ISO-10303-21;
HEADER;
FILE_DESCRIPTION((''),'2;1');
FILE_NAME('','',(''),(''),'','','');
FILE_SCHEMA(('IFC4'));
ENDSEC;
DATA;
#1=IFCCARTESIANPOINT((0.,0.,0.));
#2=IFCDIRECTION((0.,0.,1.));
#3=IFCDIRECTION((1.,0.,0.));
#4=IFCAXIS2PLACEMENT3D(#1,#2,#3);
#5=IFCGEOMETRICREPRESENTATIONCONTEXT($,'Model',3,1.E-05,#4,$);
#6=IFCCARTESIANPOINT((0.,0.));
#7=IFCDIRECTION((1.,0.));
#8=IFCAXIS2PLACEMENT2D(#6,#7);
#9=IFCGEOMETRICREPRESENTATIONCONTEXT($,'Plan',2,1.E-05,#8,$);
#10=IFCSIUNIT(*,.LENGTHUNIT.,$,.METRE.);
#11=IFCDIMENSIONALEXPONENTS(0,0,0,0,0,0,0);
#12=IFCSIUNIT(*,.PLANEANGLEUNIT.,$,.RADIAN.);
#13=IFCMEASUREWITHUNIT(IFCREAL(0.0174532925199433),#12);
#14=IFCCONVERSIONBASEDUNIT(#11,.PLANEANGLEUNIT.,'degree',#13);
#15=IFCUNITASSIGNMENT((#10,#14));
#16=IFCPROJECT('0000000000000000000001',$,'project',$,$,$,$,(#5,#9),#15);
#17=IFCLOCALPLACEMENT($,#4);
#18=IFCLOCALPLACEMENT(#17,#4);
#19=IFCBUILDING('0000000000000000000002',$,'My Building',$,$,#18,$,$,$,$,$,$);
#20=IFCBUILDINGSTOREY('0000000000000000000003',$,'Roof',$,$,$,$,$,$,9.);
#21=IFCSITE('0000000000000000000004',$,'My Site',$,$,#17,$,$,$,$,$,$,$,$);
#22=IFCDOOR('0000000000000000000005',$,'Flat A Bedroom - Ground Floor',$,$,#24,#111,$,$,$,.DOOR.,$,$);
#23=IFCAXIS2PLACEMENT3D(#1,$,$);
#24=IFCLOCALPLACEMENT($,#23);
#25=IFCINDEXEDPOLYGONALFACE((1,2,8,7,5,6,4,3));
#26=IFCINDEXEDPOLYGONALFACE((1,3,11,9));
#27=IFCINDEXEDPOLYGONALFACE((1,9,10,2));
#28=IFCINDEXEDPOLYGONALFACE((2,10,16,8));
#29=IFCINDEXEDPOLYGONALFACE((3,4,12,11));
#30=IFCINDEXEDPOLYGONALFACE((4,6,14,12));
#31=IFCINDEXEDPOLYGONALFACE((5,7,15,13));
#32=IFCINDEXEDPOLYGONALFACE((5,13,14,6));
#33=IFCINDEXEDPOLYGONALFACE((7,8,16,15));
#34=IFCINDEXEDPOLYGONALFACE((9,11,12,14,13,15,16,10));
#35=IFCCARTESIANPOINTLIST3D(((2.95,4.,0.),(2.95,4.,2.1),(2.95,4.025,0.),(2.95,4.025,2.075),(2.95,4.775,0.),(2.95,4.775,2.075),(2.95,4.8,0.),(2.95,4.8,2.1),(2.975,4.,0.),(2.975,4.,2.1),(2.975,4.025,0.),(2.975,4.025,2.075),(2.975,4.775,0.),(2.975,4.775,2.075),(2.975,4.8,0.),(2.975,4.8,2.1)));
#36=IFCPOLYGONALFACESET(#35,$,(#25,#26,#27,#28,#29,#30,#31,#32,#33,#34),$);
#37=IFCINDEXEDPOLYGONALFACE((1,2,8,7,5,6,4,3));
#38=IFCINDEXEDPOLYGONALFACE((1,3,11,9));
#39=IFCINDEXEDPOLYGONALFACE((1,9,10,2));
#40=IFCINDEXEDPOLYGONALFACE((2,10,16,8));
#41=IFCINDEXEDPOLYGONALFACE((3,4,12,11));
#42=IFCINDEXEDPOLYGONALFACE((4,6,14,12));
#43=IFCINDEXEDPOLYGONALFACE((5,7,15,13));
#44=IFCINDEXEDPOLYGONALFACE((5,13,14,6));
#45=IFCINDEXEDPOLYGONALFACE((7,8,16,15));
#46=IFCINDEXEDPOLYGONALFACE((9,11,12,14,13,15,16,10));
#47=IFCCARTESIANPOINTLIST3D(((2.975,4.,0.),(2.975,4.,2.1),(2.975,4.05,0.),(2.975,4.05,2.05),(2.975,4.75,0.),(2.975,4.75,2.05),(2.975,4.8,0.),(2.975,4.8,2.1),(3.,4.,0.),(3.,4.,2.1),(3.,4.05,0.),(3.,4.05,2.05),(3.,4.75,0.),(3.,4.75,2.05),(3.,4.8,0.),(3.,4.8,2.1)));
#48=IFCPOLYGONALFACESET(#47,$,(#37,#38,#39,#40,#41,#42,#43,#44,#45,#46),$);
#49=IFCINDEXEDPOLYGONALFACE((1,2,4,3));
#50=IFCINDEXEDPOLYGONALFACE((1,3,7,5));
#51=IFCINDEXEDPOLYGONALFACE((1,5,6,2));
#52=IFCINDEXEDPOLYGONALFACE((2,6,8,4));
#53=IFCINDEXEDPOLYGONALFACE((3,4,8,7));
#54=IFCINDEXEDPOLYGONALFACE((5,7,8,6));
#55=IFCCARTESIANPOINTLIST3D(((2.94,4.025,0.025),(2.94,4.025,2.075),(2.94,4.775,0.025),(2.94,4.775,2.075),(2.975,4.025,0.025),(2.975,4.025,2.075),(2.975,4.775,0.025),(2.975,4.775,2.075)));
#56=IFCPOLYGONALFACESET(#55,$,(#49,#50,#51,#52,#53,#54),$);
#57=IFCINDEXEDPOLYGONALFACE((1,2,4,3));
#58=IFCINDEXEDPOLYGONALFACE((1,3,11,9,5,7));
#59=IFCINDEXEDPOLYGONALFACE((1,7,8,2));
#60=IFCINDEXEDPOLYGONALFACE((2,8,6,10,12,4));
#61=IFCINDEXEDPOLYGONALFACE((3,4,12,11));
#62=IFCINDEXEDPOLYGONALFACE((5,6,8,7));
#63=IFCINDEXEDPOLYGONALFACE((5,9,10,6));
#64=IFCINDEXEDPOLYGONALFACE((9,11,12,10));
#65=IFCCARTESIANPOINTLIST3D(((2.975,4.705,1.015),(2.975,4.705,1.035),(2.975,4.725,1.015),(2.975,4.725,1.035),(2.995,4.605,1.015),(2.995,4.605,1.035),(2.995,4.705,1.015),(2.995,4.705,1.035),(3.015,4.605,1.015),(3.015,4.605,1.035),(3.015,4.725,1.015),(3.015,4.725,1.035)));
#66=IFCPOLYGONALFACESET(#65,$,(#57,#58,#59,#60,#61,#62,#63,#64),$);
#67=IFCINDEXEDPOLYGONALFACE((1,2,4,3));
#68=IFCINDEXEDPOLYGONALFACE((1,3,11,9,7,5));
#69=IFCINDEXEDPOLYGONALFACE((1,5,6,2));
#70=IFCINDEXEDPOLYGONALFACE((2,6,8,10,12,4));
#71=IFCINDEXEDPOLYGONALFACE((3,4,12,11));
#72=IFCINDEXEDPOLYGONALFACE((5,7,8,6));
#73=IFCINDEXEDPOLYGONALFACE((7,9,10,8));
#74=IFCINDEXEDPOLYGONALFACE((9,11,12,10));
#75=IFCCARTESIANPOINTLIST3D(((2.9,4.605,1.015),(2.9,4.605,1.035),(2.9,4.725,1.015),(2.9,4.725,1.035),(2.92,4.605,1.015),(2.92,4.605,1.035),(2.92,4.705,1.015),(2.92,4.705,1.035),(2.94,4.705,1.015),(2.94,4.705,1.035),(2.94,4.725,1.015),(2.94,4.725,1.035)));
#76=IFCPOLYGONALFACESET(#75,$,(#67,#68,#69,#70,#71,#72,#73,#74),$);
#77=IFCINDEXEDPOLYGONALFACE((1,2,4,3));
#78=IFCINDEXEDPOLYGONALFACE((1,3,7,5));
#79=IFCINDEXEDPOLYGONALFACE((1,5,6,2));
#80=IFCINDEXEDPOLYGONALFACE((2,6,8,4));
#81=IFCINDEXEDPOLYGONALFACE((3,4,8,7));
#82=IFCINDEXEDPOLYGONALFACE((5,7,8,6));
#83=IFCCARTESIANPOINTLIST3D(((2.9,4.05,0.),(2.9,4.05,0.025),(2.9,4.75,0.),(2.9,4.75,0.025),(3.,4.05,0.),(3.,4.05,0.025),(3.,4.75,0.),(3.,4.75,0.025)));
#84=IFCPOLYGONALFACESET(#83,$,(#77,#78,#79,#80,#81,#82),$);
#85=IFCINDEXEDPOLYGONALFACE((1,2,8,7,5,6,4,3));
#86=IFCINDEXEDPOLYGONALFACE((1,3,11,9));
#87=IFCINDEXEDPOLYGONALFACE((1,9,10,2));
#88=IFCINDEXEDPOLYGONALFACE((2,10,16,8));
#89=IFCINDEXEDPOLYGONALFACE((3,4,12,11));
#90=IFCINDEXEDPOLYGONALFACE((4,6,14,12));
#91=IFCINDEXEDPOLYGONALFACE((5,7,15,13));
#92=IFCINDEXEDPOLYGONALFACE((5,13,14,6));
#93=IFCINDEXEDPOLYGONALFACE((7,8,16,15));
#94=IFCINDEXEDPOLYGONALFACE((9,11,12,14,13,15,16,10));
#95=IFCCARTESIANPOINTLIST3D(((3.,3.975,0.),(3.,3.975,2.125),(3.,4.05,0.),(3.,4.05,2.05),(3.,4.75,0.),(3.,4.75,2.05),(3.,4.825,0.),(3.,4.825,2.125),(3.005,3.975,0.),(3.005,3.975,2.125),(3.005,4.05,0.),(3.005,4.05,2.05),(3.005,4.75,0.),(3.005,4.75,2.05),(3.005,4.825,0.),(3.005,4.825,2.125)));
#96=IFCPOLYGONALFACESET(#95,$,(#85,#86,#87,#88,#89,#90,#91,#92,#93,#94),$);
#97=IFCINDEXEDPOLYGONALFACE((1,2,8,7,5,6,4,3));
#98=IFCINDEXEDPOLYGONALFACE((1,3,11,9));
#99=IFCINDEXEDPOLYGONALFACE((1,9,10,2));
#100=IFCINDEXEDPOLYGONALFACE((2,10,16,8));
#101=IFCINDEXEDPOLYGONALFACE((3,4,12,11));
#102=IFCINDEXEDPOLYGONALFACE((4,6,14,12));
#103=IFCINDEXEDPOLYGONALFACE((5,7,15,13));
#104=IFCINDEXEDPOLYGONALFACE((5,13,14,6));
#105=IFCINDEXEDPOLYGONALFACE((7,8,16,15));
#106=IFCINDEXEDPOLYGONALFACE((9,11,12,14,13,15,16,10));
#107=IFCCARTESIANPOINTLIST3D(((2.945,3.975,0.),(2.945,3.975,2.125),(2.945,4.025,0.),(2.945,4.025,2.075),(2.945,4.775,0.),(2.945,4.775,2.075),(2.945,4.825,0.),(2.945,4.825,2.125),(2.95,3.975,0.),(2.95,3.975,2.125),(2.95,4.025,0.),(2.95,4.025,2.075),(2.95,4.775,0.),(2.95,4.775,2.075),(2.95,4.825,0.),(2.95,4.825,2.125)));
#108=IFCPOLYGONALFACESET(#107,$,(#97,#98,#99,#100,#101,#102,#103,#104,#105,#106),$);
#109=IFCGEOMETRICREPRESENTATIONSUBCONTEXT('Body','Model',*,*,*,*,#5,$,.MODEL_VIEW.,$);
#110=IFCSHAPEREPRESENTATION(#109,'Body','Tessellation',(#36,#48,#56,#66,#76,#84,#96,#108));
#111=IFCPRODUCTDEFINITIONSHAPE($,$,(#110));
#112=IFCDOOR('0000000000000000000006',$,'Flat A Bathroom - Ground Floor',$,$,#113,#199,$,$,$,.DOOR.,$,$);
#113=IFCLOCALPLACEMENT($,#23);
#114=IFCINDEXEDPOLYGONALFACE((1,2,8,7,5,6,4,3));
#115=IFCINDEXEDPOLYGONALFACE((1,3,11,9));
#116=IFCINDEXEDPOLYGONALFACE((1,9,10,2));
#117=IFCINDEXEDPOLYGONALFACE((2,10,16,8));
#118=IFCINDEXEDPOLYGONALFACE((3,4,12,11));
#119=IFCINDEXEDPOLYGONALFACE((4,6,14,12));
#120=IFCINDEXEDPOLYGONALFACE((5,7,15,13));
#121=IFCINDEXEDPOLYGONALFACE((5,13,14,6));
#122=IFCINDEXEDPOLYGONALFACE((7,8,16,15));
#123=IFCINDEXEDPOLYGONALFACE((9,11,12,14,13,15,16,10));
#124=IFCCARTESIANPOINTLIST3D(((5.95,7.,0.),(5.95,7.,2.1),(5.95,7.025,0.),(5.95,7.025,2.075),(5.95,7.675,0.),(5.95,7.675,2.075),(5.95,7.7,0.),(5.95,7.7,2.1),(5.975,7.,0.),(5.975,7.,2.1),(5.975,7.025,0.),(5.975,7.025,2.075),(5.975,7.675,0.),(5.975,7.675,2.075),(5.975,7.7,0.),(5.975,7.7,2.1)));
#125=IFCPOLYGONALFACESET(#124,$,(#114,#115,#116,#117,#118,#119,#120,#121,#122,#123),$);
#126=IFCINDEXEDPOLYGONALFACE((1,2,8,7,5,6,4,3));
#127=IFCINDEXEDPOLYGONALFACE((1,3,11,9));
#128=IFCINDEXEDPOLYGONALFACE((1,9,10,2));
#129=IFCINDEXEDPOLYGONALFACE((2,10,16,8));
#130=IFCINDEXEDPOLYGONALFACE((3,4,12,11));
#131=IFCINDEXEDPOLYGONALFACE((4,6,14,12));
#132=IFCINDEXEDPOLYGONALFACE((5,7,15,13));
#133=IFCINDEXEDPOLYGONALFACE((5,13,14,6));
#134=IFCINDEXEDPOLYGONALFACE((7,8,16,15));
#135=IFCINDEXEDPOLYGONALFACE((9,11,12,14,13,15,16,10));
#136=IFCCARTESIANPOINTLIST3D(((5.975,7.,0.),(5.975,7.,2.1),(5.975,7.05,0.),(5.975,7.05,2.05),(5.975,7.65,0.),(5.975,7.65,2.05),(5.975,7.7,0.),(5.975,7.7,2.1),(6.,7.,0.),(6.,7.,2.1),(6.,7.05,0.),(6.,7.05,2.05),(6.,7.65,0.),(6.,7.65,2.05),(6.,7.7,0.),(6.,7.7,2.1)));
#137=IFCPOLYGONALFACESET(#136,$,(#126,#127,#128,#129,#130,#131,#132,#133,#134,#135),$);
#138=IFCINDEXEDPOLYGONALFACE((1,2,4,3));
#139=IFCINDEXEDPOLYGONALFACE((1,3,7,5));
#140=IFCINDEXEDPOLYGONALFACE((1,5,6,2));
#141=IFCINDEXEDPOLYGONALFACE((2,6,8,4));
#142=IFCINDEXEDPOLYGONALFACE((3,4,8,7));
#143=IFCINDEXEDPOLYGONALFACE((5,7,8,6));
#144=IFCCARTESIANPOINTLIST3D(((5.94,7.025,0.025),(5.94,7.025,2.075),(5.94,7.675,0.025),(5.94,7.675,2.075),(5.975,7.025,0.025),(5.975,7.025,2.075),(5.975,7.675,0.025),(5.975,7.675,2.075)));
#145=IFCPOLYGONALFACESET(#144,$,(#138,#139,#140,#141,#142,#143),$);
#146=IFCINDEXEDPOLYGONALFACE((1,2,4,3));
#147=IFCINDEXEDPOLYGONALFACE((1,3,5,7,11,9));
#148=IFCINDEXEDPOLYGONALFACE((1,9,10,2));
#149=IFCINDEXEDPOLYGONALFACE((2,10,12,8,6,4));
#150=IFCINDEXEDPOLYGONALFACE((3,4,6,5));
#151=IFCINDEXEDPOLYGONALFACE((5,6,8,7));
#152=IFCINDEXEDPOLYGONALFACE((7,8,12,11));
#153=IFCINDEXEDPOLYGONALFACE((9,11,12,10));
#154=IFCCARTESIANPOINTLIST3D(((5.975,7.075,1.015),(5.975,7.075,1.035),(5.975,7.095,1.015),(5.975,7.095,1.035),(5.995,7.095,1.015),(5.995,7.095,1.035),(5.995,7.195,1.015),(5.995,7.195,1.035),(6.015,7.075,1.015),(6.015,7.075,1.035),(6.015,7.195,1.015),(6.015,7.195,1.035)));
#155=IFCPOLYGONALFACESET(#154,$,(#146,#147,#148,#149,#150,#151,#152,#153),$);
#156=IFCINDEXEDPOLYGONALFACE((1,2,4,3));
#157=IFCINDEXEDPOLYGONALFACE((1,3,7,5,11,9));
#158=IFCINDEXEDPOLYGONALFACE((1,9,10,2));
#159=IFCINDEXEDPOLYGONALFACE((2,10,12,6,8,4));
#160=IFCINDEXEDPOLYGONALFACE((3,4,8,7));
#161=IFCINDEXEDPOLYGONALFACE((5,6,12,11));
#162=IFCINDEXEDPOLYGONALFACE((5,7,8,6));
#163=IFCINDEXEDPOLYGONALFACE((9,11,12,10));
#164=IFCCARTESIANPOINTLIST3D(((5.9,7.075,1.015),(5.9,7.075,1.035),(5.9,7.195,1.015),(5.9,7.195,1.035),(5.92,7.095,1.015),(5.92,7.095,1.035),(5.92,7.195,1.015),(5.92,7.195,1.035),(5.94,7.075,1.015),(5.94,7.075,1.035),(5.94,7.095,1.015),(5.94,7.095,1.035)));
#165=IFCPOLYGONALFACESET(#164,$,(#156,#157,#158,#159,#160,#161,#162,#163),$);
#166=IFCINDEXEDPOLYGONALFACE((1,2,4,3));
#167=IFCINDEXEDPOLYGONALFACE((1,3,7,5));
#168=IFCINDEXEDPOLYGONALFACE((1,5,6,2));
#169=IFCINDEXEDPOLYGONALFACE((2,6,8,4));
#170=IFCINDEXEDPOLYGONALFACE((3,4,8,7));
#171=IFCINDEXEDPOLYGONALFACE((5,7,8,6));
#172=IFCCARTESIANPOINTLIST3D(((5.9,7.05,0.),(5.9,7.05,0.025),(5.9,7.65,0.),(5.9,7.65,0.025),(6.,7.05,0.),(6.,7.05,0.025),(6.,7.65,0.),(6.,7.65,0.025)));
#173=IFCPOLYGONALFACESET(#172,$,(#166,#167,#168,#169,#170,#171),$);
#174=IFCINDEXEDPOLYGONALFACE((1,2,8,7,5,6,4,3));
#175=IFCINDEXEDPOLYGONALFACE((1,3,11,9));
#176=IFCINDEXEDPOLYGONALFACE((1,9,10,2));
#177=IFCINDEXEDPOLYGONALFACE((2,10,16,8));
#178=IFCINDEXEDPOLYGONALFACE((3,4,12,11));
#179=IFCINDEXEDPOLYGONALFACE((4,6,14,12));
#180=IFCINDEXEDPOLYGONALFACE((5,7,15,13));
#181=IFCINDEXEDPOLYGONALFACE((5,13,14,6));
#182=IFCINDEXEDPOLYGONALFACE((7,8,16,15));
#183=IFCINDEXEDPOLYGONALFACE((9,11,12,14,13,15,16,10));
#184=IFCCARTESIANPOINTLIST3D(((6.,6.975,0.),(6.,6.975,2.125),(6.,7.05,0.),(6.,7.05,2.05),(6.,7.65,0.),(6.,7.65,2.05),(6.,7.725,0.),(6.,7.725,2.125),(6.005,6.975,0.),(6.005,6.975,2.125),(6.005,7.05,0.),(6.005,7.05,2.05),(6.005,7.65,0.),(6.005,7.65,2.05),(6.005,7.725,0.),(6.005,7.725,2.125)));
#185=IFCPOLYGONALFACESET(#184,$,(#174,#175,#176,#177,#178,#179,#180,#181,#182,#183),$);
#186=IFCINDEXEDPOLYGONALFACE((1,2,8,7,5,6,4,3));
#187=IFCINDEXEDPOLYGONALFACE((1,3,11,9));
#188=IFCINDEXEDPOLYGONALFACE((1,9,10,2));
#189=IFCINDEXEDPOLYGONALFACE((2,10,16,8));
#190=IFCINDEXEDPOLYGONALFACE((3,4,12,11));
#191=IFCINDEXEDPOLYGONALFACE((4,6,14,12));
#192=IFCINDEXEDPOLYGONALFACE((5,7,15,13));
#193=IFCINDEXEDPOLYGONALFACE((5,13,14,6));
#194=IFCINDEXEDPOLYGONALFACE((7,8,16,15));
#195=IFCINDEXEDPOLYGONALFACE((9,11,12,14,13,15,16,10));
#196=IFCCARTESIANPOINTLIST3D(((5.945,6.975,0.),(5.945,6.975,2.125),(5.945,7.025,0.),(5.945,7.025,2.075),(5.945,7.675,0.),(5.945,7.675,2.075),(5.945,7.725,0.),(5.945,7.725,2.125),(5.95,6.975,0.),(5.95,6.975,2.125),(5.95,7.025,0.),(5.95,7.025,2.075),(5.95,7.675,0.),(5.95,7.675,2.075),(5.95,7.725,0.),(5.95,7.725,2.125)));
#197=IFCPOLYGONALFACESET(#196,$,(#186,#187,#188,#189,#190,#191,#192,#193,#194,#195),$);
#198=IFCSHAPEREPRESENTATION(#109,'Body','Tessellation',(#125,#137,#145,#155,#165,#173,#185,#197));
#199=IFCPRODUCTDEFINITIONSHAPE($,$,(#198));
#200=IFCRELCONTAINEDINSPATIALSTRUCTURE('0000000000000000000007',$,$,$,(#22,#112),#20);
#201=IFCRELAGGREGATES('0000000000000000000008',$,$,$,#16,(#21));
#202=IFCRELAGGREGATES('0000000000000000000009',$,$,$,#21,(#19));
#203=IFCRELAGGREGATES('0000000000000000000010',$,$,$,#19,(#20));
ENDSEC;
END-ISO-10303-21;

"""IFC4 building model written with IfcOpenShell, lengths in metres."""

from ifc_helpers import new_model, entity, si_unit, converted_unit, frame, origin_with_axes, origin_2d_with_axis, place, context, subcontext, project, spatial, line, indexed_curve, outline, extrude, element, save


model = new_model("IFC4")

# Units and contexts
model_context = context("Model", 3, precision=1e-05, world=origin_with_axes())
plan_context = context("Plan", 2, precision=1e-05, world=origin_2d_with_axis())
body_context = subcontext(model_context, "Body", "Model", "MODEL_VIEW")
ifc_project = project(units=[si_unit("LENGTHUNIT", "METRE"), converted_unit("PLANEANGLEUNIT", "degree", entity("IfcReal", 0.0174532925199433), si_unit("PLANEANGLEUNIT", "RADIAN"), dimensions=[0, 0, 0, 0, 0, 0, 0])], contexts=[model_context, plan_context])

# Site, building, storey
site_placement = place(None, origin_with_axes())
site = spatial("IfcSite", under=ifc_project, at=site_placement, Name="My Site")
building_placement = place(site_placement, origin_with_axes())
building = spatial("IfcBuilding", under=site, at=building_placement, Name="My Building")
storey = spatial("IfcBuildingStorey", under=building, Name="Roof", Elevation=9.0)

# Doors
door_1_placement = place(None, frame((3.0, 4.0, 0.0), z_axis=(0.0, 0.0, 1.0), x_axis=(0.0, 1.0, 0.0)))
element("IfcDoor", 1, at=door_1_placement, inside=storey, Name="Flat A Bedroom - Ground Floor", PredefinedType="DOOR", context=body_context, shape_type="SweptSolid", body=[
    extrude(outline(indexed_curve([(0.0, 0.0), (0.0, 2.1), (0.8, 2.1), (0.8, 0.0), (0.775, 0.0), (0.775, 2.075), (0.025, 2.075), (0.025, 0.0)], segments=[line(1, 2, 3, 4, 5, 6, 7, 8, 1)])), frame((0.0, 0.025, 0.0), z_axis=(0.0, -1.0, 0.0), x_axis=(1.0, 0.0, 0.0)), (0.0, 0.0, -1.0), 0.025),
    extrude(outline(indexed_curve([(0.0, 0.0), (0.0, 2.1), (0.8, 2.1), (0.8, 0.0), (0.75, 0.0), (0.75, 2.05), (0.05, 2.05), (0.05, 0.0)], segments=[line(1, 2, 3, 4, 5, 6, 7, 8, 1)])), frame((0.0, 0.0, 0.0), z_axis=(0.0, -1.0, 0.0), x_axis=(1.0, 0.0, 0.0)), (0.0, 0.0, -1.0), 0.025),
    extrude(outline(indexed_curve([(0.0, 0.0), (0.75, 0.0), (0.75, 0.035), (0.0, 0.035)], segments=[line(1, 2, 3, 4, 1)])), frame((0.025, 0.025, 0.025), z_axis=(0.0, 0.0, 1.0), x_axis=(1.0, 0.0, 0.0)), (0.0, 0.0, 1.0), 2.05),
    extrude(outline(indexed_curve([(0.0, 0.0), (0.0, -0.04), (-0.12, -0.04), (-0.12, -0.02), (-0.02, -0.02), (-0.02, 0.0)], segments=[line(1, 2, 3, 4, 5, 6, 1)])), frame((0.725, 0.025, 1.015), z_axis=(0.0, 0.0, 1.0), x_axis=(1.0, 0.0, 0.0)), (0.0, 0.0, 1.0), 0.02),
    extrude(outline(indexed_curve([(0.0, 0.0), (0.0, 0.04), (-0.12, 0.04), (-0.12, 0.02), (-0.02, 0.02), (-0.02, 0.0)], segments=[line(1, 2, 3, 4, 5, 6, 1)])), frame((0.725, 0.06, 1.015), z_axis=(0.0, 0.0, 1.0), x_axis=(1.0, 0.0, 0.0)), (0.0, 0.0, 1.0), 0.02),
    extrude(outline(indexed_curve([(0.0, 0.0), (0.7, 0.0), (0.7, 0.1), (0.0, 0.1)], segments=[line(1, 2, 3, 4, 1)])), frame((0.05, 0.0, 0.0), z_axis=(0.0, 0.0, 1.0), x_axis=(1.0, 0.0, 0.0)), (0.0, 0.0, 1.0), 0.025),
    extrude(outline(indexed_curve([(0.0, 0.0), (0.0, 2.125), (0.85, 2.125), (0.85, 0.0), (0.775, 0.0), (0.775, 2.05), (0.075, 2.05), (0.075, 0.0)], segments=[line(1, 2, 3, 4, 5, 6, 7, 8, 1)])), frame((-0.025, -0.005, 0.0), z_axis=(0.0, -1.0, 0.0), x_axis=(1.0, 0.0, 0.0)), (0.0, 0.0, -1.0), 0.005),
    extrude(outline(indexed_curve([(0.0, 0.0), (0.0, 2.125), (0.85, 2.125), (0.85, 0.0), (0.8, 0.0), (0.8, 2.075), (0.05, 2.075), (0.05, 0.0)], segments=[line(1, 2, 3, 4, 5, 6, 7, 8, 1)])), frame((-0.025, 0.05, 0.0), z_axis=(0.0, -1.0, 0.0), x_axis=(1.0, 0.0, 0.0)), (0.0, 0.0, -1.0), 0.005),
])
door_2_placement = place(None, frame((6.0, 7.0, 0.0), z_axis=(0.0, 0.0, 1.0), x_axis=(0.0, 1.0, 0.0)))
element("IfcDoor", 2, at=door_2_placement, inside=storey, Name="Flat A Bathroom - Ground Floor", PredefinedType="DOOR", context=body_context, shape_type="SweptSolid", body=[
    extrude(outline(indexed_curve([(0.0, 0.0), (0.0, 2.1), (0.7, 2.1), (0.7, 0.0), (0.675, 0.0), (0.675, 2.075), (0.025, 2.075), (0.025, 0.0)], segments=[line(1, 2, 3, 4, 5, 6, 7, 8, 1)])), frame((0.0, 0.025, 0.0), z_axis=(0.0, -1.0, 0.0), x_axis=(1.0, 0.0, 0.0)), (0.0, 0.0, -1.0), 0.025),
    extrude(outline(indexed_curve([(0.0, 0.0), (0.0, 2.1), (0.7, 2.1), (0.7, 0.0), (0.65, 0.0), (0.65, 2.05), (0.05, 2.05), (0.05, 0.0)], segments=[line(1, 2, 3, 4, 5, 6, 7, 8, 1)])), frame((0.0, 0.0, 0.0), z_axis=(0.0, -1.0, 0.0), x_axis=(1.0, 0.0, 0.0)), (0.0, 0.0, -1.0), 0.025),
    extrude(outline(indexed_curve([(0.0, 0.0), (0.65, 0.0), (0.65, 0.035), (0.0, 0.035)], segments=[line(1, 2, 3, 4, 1)])), frame((0.025, 0.025, 0.025), z_axis=(0.0, 0.0, 1.0), x_axis=(1.0, 0.0, 0.0)), (0.0, 0.0, 1.0), 2.05),
    extrude(outline(indexed_curve([(0.0, 0.0), (0.0, -0.04), (0.12, -0.04), (0.12, -0.02), (0.02, -0.02), (0.02, 0.0)], segments=[line(1, 2, 3, 4, 5, 6, 1)])), frame((0.075, 0.025, 1.015), z_axis=(0.0, 0.0, 1.0), x_axis=(1.0, 0.0, 0.0)), (0.0, 0.0, 1.0), 0.02),
    extrude(outline(indexed_curve([(0.0, 0.0), (0.0, 0.04), (0.12, 0.04), (0.12, 0.02), (0.02, 0.02), (0.02, 0.0)], segments=[line(1, 2, 3, 4, 5, 6, 1)])), frame((0.075, 0.06, 1.015), z_axis=(0.0, 0.0, 1.0), x_axis=(1.0, 0.0, 0.0)), (0.0, 0.0, 1.0), 0.02),
    extrude(outline(indexed_curve([(0.0, 0.0), (0.6, 0.0), (0.6, 0.1), (0.0, 0.1)], segments=[line(1, 2, 3, 4, 1)])), frame((0.05, 0.0, 0.0), z_axis=(0.0, 0.0, 1.0), x_axis=(1.0, 0.0, 0.0)), (0.0, 0.0, 1.0), 0.025),
    extrude(outline(indexed_curve([(0.0, 0.0), (0.0, 2.125), (0.75, 2.125), (0.75, 0.0), (0.675, 0.0), (0.675, 2.05), (0.075, 2.05), (0.075, 0.0)], segments=[line(1, 2, 3, 4, 5, 6, 7, 8, 1)])), frame((-0.025, -0.005, 0.0), z_axis=(0.0, -1.0, 0.0), x_axis=(1.0, 0.0, 0.0)), (0.0, 0.0, -1.0), 0.005),
    extrude(outline(indexed_curve([(0.0, 0.0), (0.0, 2.125), (0.75, 2.125), (0.75, 0.0), (0.7, 0.0), (0.7, 2.075), (0.05, 2.075), (0.05, 0.0)], segments=[line(1, 2, 3, 4, 5, 6, 7, 8, 1)])), frame((-0.025, 0.05, 0.0), z_axis=(0.0, -1.0, 0.0), x_axis=(1.0, 0.0, 0.0)), (0.0, 0.0, -1.0), 0.005),
])

save(model, "model.ifc")
